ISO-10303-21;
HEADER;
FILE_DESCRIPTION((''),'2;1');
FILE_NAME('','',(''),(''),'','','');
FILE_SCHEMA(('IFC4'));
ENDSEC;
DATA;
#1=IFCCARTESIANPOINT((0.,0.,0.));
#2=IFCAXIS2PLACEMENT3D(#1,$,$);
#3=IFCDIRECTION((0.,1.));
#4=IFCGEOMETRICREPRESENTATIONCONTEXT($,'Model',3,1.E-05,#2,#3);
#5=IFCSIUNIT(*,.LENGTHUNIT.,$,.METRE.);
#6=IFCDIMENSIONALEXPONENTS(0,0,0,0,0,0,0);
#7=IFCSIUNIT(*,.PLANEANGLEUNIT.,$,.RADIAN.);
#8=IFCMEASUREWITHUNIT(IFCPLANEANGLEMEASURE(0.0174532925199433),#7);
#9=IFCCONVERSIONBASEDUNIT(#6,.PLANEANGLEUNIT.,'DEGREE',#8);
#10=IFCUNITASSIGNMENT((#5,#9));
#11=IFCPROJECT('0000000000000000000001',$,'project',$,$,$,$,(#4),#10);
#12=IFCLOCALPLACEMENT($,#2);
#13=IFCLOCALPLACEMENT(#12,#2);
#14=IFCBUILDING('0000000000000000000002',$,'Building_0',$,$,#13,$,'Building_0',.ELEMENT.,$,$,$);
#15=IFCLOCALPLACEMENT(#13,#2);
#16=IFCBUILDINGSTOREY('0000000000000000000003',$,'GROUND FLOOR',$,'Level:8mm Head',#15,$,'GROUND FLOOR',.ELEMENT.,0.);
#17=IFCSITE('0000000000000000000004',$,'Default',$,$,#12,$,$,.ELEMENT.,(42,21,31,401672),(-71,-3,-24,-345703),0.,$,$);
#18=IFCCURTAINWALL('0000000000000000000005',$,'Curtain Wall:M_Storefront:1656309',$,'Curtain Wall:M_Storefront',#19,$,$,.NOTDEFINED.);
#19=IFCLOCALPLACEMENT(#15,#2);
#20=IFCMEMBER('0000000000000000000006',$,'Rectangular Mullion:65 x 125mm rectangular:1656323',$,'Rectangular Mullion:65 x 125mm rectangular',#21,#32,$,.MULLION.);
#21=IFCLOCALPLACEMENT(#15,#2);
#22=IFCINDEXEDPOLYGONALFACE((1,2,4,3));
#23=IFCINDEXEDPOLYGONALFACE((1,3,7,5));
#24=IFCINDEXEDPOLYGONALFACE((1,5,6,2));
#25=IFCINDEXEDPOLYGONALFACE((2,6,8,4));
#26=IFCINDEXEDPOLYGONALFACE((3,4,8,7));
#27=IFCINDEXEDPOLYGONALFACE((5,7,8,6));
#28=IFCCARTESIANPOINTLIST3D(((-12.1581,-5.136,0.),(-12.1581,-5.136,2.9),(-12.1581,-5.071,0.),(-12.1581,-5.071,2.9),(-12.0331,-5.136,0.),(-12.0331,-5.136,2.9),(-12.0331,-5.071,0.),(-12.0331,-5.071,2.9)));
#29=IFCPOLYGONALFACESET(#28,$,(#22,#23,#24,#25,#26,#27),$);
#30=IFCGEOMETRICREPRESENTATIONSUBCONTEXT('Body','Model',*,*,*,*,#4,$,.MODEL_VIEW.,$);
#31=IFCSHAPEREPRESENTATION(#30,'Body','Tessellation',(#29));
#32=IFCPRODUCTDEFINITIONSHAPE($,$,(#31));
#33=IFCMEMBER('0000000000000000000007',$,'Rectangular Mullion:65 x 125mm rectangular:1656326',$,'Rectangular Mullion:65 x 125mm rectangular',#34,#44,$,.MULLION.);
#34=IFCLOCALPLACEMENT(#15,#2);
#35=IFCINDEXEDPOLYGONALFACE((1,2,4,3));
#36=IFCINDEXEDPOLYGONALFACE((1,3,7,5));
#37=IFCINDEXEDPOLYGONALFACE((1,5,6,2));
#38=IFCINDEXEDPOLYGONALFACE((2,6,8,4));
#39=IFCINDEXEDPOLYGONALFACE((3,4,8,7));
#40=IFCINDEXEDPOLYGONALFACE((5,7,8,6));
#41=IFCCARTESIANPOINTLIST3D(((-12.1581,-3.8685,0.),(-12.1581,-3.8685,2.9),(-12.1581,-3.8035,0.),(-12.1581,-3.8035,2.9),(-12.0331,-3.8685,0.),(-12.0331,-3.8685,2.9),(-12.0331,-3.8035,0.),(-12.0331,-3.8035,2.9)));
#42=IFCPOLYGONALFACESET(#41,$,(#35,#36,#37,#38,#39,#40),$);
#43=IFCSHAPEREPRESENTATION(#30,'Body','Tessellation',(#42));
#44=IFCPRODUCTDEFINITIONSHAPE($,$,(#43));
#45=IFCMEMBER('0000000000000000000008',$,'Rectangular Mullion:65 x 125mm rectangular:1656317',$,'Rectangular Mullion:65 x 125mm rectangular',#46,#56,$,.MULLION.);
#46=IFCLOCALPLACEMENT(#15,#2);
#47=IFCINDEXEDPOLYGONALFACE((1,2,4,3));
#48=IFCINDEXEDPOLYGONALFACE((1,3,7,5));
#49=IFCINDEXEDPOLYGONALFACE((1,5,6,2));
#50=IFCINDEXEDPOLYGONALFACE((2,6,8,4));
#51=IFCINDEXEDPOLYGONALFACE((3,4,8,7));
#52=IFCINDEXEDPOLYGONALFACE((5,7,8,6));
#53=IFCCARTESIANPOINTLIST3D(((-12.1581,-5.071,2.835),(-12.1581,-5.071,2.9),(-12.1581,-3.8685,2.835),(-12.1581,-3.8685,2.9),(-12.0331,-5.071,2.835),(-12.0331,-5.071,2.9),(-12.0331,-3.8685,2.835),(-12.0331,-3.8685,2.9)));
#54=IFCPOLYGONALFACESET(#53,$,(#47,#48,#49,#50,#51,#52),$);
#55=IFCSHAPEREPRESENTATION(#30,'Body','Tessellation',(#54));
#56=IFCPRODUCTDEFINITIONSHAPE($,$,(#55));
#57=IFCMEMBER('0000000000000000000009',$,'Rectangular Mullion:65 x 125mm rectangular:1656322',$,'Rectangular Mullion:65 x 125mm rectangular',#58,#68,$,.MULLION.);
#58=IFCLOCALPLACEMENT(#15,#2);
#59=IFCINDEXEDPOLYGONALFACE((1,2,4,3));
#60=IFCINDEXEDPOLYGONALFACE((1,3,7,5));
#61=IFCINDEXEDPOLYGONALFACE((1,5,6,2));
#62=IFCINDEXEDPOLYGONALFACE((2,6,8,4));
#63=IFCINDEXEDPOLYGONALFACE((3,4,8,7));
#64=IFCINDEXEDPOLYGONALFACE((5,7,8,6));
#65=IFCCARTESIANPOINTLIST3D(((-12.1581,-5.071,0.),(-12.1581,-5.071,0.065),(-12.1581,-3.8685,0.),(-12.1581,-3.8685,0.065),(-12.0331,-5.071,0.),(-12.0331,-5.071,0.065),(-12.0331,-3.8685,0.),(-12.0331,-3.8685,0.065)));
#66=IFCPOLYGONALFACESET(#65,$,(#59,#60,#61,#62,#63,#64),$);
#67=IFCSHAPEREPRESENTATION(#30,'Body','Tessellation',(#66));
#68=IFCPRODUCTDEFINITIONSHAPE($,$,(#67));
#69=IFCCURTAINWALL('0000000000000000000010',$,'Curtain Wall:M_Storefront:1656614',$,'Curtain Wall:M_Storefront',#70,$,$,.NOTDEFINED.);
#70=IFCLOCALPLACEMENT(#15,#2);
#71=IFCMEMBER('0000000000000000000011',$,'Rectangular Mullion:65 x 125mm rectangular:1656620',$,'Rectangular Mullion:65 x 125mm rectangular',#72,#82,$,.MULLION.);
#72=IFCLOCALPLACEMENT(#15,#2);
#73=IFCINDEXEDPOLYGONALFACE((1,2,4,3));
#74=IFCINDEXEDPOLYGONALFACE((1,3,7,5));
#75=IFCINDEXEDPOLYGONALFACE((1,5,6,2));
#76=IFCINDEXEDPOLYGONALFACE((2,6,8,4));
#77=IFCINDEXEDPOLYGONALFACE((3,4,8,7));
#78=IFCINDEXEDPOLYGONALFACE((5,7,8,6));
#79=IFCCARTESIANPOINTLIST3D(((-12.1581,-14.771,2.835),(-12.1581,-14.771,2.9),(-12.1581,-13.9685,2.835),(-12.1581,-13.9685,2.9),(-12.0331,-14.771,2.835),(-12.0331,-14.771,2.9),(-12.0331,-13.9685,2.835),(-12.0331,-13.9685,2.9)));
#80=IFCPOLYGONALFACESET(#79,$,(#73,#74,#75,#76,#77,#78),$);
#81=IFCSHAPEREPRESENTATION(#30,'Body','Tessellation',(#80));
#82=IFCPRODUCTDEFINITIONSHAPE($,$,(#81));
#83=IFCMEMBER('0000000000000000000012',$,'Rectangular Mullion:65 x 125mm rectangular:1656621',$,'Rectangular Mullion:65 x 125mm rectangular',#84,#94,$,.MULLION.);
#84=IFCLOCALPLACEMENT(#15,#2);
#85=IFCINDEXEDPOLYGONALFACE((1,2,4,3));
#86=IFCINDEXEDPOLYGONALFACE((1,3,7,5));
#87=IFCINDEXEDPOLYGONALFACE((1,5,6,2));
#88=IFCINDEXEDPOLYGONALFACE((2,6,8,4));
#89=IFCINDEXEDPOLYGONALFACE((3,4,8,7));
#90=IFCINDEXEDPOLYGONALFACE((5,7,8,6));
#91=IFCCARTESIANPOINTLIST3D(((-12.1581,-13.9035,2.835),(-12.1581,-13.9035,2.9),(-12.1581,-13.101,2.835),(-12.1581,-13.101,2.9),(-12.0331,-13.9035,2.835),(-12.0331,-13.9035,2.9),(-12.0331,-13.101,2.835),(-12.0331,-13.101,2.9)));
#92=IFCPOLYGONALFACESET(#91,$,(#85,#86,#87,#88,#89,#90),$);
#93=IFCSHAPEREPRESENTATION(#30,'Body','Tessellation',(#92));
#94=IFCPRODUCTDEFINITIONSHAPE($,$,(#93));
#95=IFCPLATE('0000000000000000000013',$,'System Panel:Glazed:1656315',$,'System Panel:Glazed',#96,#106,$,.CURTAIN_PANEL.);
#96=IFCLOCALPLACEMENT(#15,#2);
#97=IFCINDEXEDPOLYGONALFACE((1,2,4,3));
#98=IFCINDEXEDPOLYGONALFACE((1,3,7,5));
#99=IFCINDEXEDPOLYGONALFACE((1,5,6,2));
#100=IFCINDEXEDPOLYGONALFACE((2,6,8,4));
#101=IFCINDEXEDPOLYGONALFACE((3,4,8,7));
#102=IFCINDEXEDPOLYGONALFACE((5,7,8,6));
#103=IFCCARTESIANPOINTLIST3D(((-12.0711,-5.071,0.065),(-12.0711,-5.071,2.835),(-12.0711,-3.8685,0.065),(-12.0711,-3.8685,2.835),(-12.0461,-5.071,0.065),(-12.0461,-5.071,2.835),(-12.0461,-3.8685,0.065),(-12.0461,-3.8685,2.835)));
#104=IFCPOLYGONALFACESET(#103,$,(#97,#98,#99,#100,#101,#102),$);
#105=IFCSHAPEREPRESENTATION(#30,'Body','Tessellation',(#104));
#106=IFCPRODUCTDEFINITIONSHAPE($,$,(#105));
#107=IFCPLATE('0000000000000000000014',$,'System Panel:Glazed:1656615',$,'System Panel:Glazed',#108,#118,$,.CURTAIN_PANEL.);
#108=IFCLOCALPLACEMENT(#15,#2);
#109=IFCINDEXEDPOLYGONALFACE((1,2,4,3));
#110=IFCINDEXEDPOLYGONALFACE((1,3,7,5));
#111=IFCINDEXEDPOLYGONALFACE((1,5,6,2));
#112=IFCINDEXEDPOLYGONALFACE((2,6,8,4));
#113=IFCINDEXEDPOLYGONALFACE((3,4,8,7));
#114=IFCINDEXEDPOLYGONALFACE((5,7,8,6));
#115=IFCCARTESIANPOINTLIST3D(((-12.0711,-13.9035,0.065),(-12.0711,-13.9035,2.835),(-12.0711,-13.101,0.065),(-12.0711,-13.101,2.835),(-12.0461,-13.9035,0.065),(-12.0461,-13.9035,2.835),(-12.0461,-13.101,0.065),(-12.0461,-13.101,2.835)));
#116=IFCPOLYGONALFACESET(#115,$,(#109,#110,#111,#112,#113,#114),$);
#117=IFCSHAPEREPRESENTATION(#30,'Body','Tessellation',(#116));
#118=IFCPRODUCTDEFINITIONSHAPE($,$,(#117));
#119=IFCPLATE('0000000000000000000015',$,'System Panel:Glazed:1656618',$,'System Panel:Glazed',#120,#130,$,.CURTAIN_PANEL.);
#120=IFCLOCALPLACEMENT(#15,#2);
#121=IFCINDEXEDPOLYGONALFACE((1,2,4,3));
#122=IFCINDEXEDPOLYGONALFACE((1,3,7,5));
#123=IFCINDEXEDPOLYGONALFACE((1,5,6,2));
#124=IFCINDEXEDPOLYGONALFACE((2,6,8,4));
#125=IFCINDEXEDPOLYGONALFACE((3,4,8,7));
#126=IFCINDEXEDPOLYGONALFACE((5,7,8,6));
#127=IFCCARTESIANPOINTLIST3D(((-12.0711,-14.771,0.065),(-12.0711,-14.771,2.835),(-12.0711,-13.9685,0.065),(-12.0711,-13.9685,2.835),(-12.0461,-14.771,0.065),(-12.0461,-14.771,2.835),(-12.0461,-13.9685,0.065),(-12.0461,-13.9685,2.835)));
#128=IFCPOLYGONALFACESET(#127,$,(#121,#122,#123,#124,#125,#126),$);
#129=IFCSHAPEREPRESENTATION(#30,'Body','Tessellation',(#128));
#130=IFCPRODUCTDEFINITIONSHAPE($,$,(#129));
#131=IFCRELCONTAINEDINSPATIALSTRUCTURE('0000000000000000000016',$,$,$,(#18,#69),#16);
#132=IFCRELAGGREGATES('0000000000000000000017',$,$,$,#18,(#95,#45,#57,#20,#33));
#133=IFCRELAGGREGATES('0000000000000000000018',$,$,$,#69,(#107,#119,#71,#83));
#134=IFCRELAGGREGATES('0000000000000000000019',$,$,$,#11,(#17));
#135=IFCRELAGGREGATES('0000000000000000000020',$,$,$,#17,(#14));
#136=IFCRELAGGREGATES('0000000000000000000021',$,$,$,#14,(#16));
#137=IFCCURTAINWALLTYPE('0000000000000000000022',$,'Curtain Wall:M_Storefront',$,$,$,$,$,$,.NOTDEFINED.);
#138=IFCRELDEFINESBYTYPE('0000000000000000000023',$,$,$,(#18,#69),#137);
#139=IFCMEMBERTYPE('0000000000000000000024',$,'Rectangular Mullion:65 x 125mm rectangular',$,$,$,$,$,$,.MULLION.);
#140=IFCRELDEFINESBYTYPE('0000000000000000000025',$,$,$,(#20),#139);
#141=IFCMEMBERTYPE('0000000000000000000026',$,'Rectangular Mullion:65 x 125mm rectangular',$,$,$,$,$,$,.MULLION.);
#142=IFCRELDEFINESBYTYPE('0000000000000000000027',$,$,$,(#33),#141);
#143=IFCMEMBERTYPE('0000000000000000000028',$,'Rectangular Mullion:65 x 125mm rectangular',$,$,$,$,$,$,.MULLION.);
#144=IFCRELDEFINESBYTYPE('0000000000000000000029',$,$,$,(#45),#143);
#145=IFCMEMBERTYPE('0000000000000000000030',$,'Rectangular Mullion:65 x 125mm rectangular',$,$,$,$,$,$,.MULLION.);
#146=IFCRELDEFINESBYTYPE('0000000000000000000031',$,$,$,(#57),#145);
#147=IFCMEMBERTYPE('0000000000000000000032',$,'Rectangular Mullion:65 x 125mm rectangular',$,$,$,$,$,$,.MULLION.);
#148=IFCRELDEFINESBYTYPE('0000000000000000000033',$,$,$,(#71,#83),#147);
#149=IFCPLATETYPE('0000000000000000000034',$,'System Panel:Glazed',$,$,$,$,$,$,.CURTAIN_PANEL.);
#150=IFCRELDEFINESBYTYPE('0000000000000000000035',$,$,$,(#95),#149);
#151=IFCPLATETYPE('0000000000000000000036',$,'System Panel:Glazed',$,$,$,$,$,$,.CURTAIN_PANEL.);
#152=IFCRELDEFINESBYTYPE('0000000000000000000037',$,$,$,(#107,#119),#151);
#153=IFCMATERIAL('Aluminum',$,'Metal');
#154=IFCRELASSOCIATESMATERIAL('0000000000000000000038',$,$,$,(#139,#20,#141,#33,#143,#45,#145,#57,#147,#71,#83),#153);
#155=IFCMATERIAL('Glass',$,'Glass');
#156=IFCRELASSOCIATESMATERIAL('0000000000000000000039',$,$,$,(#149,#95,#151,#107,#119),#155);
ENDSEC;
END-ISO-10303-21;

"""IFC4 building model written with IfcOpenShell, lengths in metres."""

from ifc_helpers import new_model, entity, si_unit, converted_unit, direction, frame, origin, place, context, subcontext, project, spatial, indexed_curve, outline, extrude, source, transform, mapped, material, type_object, type_shapes, element, aggregate, save


model = new_model("IFC4")

# Units and contexts
model_context = context("Model", 3, precision=1e-05, world=origin(), true_north=direction((0.0, 1.0)))
body_context = subcontext(model_context, "Body", "Model", "MODEL_VIEW")
ifc_project = project(units=[si_unit("LENGTHUNIT", "METRE"), converted_unit("PLANEANGLEUNIT", "DEGREE", entity("IfcPlaneAngleMeasure", 0.0174532925199433), si_unit("PLANEANGLEUNIT", "RADIAN"), dimensions=[0, 0, 0, 0, 0, 0, 0])], contexts=[model_context])

# Site, building, storey
site_placement = place(None, origin())
site = spatial("IfcSite", under=ifc_project, at=site_placement, Name="Default", CompositionType="ELEMENT", RefLatitude=(42, 21, 31, 401672), RefLongitude=(-71, -3, -24, -345703), RefElevation=0.0)
building_placement = place(site_placement, origin())
building = spatial("IfcBuilding", under=site, at=building_placement, Name="Building_0", LongName="Building_0", CompositionType="ELEMENT")
storey_placement = place(building_placement, origin())
storey = spatial("IfcBuildingStorey", under=building, at=storey_placement, Name="GROUND FLOOR", ObjectType="Level:8mm Head", LongName="GROUND FLOOR", CompositionType="ELEMENT", Elevation=0.0)

# Curtain walls, members
curtain_wall_type = type_object("IfcCurtainWallType", Name="Curtain Wall:M_Storefront", PredefinedType="NOTDEFINED")
curtain_wall_1_placement = place(storey_placement, origin())
curtain_wall_1 = element("IfcCurtainWall", 1, at=curtain_wall_1_placement, inside=storey, type_object=curtain_wall_type, Name="Curtain Wall:M_Storefront:1656309", ObjectType="Curtain Wall:M_Storefront", PredefinedType="NOTDEFINED")
ifc_material_1 = material(Name="Aluminum", Category="Metal")
member_type_1 = type_object("IfcMemberType", Name="Rectangular Mullion:65 x 125mm rectangular", PredefinedType="MULLION", material=ifc_material_1)
shared_shape_1 = source(origin(), body_context, "Body", "SweptSolid", [
    extrude(outline(indexed_curve([(-0.0325, -0.0625), (0.0325, -0.0625), (0.0325, 0.0625), (-0.0325, 0.0625), (-0.0325, -0.0625)], self_intersect=False)), frame((-0.0325, 0.0, -2.9), z_axis=(0.0, 0.0, 1.0), x_axis=(-1.0, 0.0, 0.0)), (0.0, 0.0, 1.0), 2.9),
])
type_shapes(member_type_1, [shared_shape_1])
member_1_placement = place(curtain_wall_1_placement, frame((-12.0956, -5.136, 0.0), z_axis=(0.0, 0.0, -1.0), x_axis=(0.0, -1.0, 0.0)))
member_1 = element("IfcMember", 2, at=member_1_placement, type_object=member_type_1, material=ifc_material_1, Name="Rectangular Mullion:65 x 125mm rectangular:1656323", ObjectType="Rectangular Mullion:65 x 125mm rectangular", PredefinedType="MULLION", context=body_context, shape_type="MappedRepresentation", body=[
    mapped(shared_shape_1, transform((0.0, 0.0, 0.0), scale=1.0)),
])
member_type_2 = type_object("IfcMemberType", Name="Rectangular Mullion:65 x 125mm rectangular", PredefinedType="MULLION", material=ifc_material_1)
shared_shape_2 = source(origin(), body_context, "Body", "SweptSolid", [
    extrude(outline(indexed_curve([(-0.0325, -0.0625), (0.0325, -0.0625), (0.0325, 0.0625), (-0.0325, 0.0625), (-0.0325, -0.0625)], self_intersect=False)), frame((0.0, 0.0, -2.9), z_axis=(0.0, 0.0, 1.0), x_axis=(-1.0, 0.0, 0.0)), (0.0, 0.0, 1.0), 2.9),
])
type_shapes(member_type_2, [shared_shape_2])
member_2_placement = place(curtain_wall_1_placement, frame((-12.0956, -3.836, 0.0), z_axis=(0.0, 0.0, -1.0), x_axis=(0.0, -1.0, 0.0)))
member_2 = element("IfcMember", 3, at=member_2_placement, type_object=member_type_2, material=ifc_material_1, Name="Rectangular Mullion:65 x 125mm rectangular:1656326", ObjectType="Rectangular Mullion:65 x 125mm rectangular", PredefinedType="MULLION", context=body_context, shape_type="MappedRepresentation", body=[
    mapped(shared_shape_2, transform((0.0, 0.0, 0.0), scale=1.0)),
])
member_type_3 = type_object("IfcMemberType", Name="Rectangular Mullion:65 x 125mm rectangular", PredefinedType="MULLION", material=ifc_material_1)
shared_shape_3 = source(origin(), body_context, "Body", "SweptSolid", [
    extrude(outline(indexed_curve([(-0.0325, -0.0625), (0.0325, -0.0625), (0.0325, 0.0625), (-0.0325, 0.0625), (-0.0325, -0.0625)], self_intersect=False)), frame((-0.0325, 0.0, -1.2025), z_axis=(0.0, 0.0, 1.0), x_axis=(-1.0, 0.0, 0.0)), (0.0, 0.0, 1.0), 1.2025),
])
type_shapes(member_type_3, [shared_shape_3])
member_3_placement = place(curtain_wall_1_placement, frame((-12.0956, -5.071, 2.9), z_axis=(0.0, -1.0, 0.0), x_axis=(0.0, 0.0, 1.0)))
member_3 = element("IfcMember", 4, at=member_3_placement, type_object=member_type_3, material=ifc_material_1, Name="Rectangular Mullion:65 x 125mm rectangular:1656317", ObjectType="Rectangular Mullion:65 x 125mm rectangular", PredefinedType="MULLION", context=body_context, shape_type="MappedRepresentation", body=[
    mapped(shared_shape_3, transform((0.0, 0.0, 0.0), scale=1.0)),
])
member_type_4 = type_object("IfcMemberType", Name="Rectangular Mullion:65 x 125mm rectangular", PredefinedType="MULLION", material=ifc_material_1)
shared_shape_4 = source(origin(), body_context, "Body", "SweptSolid", [
    extrude(outline(indexed_curve([(-0.0325, -0.0625), (0.0325, -0.0625), (0.0325, 0.0625), (-0.0325, 0.0625), (-0.0325, -0.0625)], self_intersect=False)), frame((-0.0325, 0.0, -1.2025), z_axis=(0.0, 0.0, 1.0), x_axis=(-1.0, 0.0, 0.0)), (0.0, 0.0, 1.0), 1.2025),
])
type_shapes(member_type_4, [shared_shape_4])
member_4_placement = place(curtain_wall_1_placement, frame((-12.0956, -3.8685, 0.0), z_axis=(0.0, 1.0, 0.0), x_axis=(0.0, 0.0, -1.0)))
member_4 = element("IfcMember", 5, at=member_4_placement, type_object=member_type_4, material=ifc_material_1, Name="Rectangular Mullion:65 x 125mm rectangular:1656322", ObjectType="Rectangular Mullion:65 x 125mm rectangular", PredefinedType="MULLION", context=body_context, shape_type="MappedRepresentation", body=[
    mapped(shared_shape_4, transform((0.0, 0.0, 0.0), scale=1.0)),
])
curtain_wall_2_placement = place(storey_placement, origin())
curtain_wall_2 = element("IfcCurtainWall", 6, at=curtain_wall_2_placement, inside=storey, type_object=curtain_wall_type, Name="Curtain Wall:M_Storefront:1656614", ObjectType="Curtain Wall:M_Storefront", PredefinedType="NOTDEFINED")
member_type_5 = type_object("IfcMemberType", Name="Rectangular Mullion:65 x 125mm rectangular", PredefinedType="MULLION", material=ifc_material_1)
shared_shape_5 = source(origin(), body_context, "Body", "SweptSolid", [
    extrude(outline(indexed_curve([(-0.0325, -0.0625), (0.0325, -0.0625), (0.0325, 0.0625), (-0.0325, 0.0625), (-0.0325, -0.0625)], self_intersect=False)), frame((-0.0325, 0.0, -0.8025), z_axis=(0.0, 0.0, 1.0), x_axis=(-1.0, 0.0, 0.0)), (0.0, 0.0, 1.0), 0.8025),
])
type_shapes(member_type_5, [shared_shape_5])
member_5_placement = place(curtain_wall_2_placement, frame((-12.0956, -14.771, 2.9), z_axis=(0.0, -1.0, 0.0), x_axis=(0.0, 0.0, 1.0)))
member_5 = element("IfcMember", 7, at=member_5_placement, type_object=member_type_5, material=ifc_material_1, Name="Rectangular Mullion:65 x 125mm rectangular:1656620", ObjectType="Rectangular Mullion:65 x 125mm rectangular", PredefinedType="MULLION", context=body_context, shape_type="MappedRepresentation", body=[
    mapped(shared_shape_5, transform((0.0, 0.0, 0.0), scale=1.0)),
])
member_6_placement = place(curtain_wall_2_placement, frame((-12.0956, -13.9035, 2.9), z_axis=(0.0, -1.0, 0.0), x_axis=(0.0, 0.0, 1.0)))
member_6 = element("IfcMember", 8, at=member_6_placement, type_object=member_type_5, material=ifc_material_1, Name="Rectangular Mullion:65 x 125mm rectangular:1656621", ObjectType="Rectangular Mullion:65 x 125mm rectangular", PredefinedType="MULLION", context=body_context, shape_type="MappedRepresentation", body=[
    mapped(shared_shape_5, transform((0.0, 0.0, 0.0), scale=1.0)),
])

# Plates
ifc_material_2 = material(Name="Glass", Category="Glass")
plate_type_1 = type_object("IfcPlateType", Name="System Panel:Glazed", PredefinedType="CURTAIN_PANEL", material=ifc_material_2)
shared_shape_6 = source(origin(), body_context, "Body", "SweptSolid", [
    extrude(outline(indexed_curve([(-0.0125, -0.6013), (0.0125, -0.6013), (0.0125, 0.6013), (-0.0125, 0.6013), (-0.0125, -0.6013)], self_intersect=False)), frame((0.0, 0.037, 0.0), z_axis=(0.0, 0.0, 1.0), x_axis=(0.0, 1.0, 0.0)), (0.0, 0.0, 1.0), 2.77),
])
type_shapes(plate_type_1, [shared_shape_6])
plate_1_placement = place(curtain_wall_1_placement, frame((-12.0956, -4.4698, 0.065), z_axis=(0.0, 0.0, 1.0), x_axis=(0.0, -1.0, 0.0)))
plate_1 = element("IfcPlate", 9, at=plate_1_placement, type_object=plate_type_1, material=ifc_material_2, Name="System Panel:Glazed:1656315", ObjectType="System Panel:Glazed", PredefinedType="CURTAIN_PANEL", context=body_context, shape_type="MappedRepresentation", body=[
    mapped(shared_shape_6, transform((0.0, 0.0, 0.0), scale=1.0)),
])
aggregate(curtain_wall_1, [plate_1, member_3, member_4, member_1, member_2])
plate_type_2 = type_object("IfcPlateType", Name="System Panel:Glazed", PredefinedType="CURTAIN_PANEL", material=ifc_material_2)
shared_shape_7 = source(origin(), body_context, "Body", "SweptSolid", [
    extrude(outline(indexed_curve([(-0.0125, -0.4012), (0.0125, -0.4012), (0.0125, 0.4012), (-0.0125, 0.4012), (-0.0125, -0.4012)], self_intersect=False)), frame((0.0, 0.037, 0.0), z_axis=(0.0, 0.0, 1.0), x_axis=(0.0, 1.0, 0.0)), (0.0, 0.0, 1.0), 2.77),
])
type_shapes(plate_type_2, [shared_shape_7])
plate_2_placement = place(curtain_wall_2_placement, frame((-12.0956, -13.5023, 0.065), z_axis=(0.0, 0.0, 1.0), x_axis=(0.0, -1.0, 0.0)))
plate_2 = element("IfcPlate", 10, at=plate_2_placement, type_object=plate_type_2, material=ifc_material_2, Name="System Panel:Glazed:1656615", ObjectType="System Panel:Glazed", PredefinedType="CURTAIN_PANEL", context=body_context, shape_type="MappedRepresentation", body=[
    mapped(shared_shape_7, transform((0.0, 0.0, 0.0), scale=1.0)),
])
plate_3_placement = place(curtain_wall_2_placement, frame((-12.0956, -14.3698, 0.065), z_axis=(0.0, 0.0, 1.0), x_axis=(0.0, -1.0, 0.0)))
plate_3 = element("IfcPlate", 11, at=plate_3_placement, type_object=plate_type_2, material=ifc_material_2, Name="System Panel:Glazed:1656618", ObjectType="System Panel:Glazed", PredefinedType="CURTAIN_PANEL", context=body_context, shape_type="MappedRepresentation", body=[
    mapped(shared_shape_7, transform((0.0, 0.0, 0.0), scale=1.0)),
])
aggregate(curtain_wall_2, [plate_2, plate_3, member_5, member_6])

save(model, "model.ifc")
